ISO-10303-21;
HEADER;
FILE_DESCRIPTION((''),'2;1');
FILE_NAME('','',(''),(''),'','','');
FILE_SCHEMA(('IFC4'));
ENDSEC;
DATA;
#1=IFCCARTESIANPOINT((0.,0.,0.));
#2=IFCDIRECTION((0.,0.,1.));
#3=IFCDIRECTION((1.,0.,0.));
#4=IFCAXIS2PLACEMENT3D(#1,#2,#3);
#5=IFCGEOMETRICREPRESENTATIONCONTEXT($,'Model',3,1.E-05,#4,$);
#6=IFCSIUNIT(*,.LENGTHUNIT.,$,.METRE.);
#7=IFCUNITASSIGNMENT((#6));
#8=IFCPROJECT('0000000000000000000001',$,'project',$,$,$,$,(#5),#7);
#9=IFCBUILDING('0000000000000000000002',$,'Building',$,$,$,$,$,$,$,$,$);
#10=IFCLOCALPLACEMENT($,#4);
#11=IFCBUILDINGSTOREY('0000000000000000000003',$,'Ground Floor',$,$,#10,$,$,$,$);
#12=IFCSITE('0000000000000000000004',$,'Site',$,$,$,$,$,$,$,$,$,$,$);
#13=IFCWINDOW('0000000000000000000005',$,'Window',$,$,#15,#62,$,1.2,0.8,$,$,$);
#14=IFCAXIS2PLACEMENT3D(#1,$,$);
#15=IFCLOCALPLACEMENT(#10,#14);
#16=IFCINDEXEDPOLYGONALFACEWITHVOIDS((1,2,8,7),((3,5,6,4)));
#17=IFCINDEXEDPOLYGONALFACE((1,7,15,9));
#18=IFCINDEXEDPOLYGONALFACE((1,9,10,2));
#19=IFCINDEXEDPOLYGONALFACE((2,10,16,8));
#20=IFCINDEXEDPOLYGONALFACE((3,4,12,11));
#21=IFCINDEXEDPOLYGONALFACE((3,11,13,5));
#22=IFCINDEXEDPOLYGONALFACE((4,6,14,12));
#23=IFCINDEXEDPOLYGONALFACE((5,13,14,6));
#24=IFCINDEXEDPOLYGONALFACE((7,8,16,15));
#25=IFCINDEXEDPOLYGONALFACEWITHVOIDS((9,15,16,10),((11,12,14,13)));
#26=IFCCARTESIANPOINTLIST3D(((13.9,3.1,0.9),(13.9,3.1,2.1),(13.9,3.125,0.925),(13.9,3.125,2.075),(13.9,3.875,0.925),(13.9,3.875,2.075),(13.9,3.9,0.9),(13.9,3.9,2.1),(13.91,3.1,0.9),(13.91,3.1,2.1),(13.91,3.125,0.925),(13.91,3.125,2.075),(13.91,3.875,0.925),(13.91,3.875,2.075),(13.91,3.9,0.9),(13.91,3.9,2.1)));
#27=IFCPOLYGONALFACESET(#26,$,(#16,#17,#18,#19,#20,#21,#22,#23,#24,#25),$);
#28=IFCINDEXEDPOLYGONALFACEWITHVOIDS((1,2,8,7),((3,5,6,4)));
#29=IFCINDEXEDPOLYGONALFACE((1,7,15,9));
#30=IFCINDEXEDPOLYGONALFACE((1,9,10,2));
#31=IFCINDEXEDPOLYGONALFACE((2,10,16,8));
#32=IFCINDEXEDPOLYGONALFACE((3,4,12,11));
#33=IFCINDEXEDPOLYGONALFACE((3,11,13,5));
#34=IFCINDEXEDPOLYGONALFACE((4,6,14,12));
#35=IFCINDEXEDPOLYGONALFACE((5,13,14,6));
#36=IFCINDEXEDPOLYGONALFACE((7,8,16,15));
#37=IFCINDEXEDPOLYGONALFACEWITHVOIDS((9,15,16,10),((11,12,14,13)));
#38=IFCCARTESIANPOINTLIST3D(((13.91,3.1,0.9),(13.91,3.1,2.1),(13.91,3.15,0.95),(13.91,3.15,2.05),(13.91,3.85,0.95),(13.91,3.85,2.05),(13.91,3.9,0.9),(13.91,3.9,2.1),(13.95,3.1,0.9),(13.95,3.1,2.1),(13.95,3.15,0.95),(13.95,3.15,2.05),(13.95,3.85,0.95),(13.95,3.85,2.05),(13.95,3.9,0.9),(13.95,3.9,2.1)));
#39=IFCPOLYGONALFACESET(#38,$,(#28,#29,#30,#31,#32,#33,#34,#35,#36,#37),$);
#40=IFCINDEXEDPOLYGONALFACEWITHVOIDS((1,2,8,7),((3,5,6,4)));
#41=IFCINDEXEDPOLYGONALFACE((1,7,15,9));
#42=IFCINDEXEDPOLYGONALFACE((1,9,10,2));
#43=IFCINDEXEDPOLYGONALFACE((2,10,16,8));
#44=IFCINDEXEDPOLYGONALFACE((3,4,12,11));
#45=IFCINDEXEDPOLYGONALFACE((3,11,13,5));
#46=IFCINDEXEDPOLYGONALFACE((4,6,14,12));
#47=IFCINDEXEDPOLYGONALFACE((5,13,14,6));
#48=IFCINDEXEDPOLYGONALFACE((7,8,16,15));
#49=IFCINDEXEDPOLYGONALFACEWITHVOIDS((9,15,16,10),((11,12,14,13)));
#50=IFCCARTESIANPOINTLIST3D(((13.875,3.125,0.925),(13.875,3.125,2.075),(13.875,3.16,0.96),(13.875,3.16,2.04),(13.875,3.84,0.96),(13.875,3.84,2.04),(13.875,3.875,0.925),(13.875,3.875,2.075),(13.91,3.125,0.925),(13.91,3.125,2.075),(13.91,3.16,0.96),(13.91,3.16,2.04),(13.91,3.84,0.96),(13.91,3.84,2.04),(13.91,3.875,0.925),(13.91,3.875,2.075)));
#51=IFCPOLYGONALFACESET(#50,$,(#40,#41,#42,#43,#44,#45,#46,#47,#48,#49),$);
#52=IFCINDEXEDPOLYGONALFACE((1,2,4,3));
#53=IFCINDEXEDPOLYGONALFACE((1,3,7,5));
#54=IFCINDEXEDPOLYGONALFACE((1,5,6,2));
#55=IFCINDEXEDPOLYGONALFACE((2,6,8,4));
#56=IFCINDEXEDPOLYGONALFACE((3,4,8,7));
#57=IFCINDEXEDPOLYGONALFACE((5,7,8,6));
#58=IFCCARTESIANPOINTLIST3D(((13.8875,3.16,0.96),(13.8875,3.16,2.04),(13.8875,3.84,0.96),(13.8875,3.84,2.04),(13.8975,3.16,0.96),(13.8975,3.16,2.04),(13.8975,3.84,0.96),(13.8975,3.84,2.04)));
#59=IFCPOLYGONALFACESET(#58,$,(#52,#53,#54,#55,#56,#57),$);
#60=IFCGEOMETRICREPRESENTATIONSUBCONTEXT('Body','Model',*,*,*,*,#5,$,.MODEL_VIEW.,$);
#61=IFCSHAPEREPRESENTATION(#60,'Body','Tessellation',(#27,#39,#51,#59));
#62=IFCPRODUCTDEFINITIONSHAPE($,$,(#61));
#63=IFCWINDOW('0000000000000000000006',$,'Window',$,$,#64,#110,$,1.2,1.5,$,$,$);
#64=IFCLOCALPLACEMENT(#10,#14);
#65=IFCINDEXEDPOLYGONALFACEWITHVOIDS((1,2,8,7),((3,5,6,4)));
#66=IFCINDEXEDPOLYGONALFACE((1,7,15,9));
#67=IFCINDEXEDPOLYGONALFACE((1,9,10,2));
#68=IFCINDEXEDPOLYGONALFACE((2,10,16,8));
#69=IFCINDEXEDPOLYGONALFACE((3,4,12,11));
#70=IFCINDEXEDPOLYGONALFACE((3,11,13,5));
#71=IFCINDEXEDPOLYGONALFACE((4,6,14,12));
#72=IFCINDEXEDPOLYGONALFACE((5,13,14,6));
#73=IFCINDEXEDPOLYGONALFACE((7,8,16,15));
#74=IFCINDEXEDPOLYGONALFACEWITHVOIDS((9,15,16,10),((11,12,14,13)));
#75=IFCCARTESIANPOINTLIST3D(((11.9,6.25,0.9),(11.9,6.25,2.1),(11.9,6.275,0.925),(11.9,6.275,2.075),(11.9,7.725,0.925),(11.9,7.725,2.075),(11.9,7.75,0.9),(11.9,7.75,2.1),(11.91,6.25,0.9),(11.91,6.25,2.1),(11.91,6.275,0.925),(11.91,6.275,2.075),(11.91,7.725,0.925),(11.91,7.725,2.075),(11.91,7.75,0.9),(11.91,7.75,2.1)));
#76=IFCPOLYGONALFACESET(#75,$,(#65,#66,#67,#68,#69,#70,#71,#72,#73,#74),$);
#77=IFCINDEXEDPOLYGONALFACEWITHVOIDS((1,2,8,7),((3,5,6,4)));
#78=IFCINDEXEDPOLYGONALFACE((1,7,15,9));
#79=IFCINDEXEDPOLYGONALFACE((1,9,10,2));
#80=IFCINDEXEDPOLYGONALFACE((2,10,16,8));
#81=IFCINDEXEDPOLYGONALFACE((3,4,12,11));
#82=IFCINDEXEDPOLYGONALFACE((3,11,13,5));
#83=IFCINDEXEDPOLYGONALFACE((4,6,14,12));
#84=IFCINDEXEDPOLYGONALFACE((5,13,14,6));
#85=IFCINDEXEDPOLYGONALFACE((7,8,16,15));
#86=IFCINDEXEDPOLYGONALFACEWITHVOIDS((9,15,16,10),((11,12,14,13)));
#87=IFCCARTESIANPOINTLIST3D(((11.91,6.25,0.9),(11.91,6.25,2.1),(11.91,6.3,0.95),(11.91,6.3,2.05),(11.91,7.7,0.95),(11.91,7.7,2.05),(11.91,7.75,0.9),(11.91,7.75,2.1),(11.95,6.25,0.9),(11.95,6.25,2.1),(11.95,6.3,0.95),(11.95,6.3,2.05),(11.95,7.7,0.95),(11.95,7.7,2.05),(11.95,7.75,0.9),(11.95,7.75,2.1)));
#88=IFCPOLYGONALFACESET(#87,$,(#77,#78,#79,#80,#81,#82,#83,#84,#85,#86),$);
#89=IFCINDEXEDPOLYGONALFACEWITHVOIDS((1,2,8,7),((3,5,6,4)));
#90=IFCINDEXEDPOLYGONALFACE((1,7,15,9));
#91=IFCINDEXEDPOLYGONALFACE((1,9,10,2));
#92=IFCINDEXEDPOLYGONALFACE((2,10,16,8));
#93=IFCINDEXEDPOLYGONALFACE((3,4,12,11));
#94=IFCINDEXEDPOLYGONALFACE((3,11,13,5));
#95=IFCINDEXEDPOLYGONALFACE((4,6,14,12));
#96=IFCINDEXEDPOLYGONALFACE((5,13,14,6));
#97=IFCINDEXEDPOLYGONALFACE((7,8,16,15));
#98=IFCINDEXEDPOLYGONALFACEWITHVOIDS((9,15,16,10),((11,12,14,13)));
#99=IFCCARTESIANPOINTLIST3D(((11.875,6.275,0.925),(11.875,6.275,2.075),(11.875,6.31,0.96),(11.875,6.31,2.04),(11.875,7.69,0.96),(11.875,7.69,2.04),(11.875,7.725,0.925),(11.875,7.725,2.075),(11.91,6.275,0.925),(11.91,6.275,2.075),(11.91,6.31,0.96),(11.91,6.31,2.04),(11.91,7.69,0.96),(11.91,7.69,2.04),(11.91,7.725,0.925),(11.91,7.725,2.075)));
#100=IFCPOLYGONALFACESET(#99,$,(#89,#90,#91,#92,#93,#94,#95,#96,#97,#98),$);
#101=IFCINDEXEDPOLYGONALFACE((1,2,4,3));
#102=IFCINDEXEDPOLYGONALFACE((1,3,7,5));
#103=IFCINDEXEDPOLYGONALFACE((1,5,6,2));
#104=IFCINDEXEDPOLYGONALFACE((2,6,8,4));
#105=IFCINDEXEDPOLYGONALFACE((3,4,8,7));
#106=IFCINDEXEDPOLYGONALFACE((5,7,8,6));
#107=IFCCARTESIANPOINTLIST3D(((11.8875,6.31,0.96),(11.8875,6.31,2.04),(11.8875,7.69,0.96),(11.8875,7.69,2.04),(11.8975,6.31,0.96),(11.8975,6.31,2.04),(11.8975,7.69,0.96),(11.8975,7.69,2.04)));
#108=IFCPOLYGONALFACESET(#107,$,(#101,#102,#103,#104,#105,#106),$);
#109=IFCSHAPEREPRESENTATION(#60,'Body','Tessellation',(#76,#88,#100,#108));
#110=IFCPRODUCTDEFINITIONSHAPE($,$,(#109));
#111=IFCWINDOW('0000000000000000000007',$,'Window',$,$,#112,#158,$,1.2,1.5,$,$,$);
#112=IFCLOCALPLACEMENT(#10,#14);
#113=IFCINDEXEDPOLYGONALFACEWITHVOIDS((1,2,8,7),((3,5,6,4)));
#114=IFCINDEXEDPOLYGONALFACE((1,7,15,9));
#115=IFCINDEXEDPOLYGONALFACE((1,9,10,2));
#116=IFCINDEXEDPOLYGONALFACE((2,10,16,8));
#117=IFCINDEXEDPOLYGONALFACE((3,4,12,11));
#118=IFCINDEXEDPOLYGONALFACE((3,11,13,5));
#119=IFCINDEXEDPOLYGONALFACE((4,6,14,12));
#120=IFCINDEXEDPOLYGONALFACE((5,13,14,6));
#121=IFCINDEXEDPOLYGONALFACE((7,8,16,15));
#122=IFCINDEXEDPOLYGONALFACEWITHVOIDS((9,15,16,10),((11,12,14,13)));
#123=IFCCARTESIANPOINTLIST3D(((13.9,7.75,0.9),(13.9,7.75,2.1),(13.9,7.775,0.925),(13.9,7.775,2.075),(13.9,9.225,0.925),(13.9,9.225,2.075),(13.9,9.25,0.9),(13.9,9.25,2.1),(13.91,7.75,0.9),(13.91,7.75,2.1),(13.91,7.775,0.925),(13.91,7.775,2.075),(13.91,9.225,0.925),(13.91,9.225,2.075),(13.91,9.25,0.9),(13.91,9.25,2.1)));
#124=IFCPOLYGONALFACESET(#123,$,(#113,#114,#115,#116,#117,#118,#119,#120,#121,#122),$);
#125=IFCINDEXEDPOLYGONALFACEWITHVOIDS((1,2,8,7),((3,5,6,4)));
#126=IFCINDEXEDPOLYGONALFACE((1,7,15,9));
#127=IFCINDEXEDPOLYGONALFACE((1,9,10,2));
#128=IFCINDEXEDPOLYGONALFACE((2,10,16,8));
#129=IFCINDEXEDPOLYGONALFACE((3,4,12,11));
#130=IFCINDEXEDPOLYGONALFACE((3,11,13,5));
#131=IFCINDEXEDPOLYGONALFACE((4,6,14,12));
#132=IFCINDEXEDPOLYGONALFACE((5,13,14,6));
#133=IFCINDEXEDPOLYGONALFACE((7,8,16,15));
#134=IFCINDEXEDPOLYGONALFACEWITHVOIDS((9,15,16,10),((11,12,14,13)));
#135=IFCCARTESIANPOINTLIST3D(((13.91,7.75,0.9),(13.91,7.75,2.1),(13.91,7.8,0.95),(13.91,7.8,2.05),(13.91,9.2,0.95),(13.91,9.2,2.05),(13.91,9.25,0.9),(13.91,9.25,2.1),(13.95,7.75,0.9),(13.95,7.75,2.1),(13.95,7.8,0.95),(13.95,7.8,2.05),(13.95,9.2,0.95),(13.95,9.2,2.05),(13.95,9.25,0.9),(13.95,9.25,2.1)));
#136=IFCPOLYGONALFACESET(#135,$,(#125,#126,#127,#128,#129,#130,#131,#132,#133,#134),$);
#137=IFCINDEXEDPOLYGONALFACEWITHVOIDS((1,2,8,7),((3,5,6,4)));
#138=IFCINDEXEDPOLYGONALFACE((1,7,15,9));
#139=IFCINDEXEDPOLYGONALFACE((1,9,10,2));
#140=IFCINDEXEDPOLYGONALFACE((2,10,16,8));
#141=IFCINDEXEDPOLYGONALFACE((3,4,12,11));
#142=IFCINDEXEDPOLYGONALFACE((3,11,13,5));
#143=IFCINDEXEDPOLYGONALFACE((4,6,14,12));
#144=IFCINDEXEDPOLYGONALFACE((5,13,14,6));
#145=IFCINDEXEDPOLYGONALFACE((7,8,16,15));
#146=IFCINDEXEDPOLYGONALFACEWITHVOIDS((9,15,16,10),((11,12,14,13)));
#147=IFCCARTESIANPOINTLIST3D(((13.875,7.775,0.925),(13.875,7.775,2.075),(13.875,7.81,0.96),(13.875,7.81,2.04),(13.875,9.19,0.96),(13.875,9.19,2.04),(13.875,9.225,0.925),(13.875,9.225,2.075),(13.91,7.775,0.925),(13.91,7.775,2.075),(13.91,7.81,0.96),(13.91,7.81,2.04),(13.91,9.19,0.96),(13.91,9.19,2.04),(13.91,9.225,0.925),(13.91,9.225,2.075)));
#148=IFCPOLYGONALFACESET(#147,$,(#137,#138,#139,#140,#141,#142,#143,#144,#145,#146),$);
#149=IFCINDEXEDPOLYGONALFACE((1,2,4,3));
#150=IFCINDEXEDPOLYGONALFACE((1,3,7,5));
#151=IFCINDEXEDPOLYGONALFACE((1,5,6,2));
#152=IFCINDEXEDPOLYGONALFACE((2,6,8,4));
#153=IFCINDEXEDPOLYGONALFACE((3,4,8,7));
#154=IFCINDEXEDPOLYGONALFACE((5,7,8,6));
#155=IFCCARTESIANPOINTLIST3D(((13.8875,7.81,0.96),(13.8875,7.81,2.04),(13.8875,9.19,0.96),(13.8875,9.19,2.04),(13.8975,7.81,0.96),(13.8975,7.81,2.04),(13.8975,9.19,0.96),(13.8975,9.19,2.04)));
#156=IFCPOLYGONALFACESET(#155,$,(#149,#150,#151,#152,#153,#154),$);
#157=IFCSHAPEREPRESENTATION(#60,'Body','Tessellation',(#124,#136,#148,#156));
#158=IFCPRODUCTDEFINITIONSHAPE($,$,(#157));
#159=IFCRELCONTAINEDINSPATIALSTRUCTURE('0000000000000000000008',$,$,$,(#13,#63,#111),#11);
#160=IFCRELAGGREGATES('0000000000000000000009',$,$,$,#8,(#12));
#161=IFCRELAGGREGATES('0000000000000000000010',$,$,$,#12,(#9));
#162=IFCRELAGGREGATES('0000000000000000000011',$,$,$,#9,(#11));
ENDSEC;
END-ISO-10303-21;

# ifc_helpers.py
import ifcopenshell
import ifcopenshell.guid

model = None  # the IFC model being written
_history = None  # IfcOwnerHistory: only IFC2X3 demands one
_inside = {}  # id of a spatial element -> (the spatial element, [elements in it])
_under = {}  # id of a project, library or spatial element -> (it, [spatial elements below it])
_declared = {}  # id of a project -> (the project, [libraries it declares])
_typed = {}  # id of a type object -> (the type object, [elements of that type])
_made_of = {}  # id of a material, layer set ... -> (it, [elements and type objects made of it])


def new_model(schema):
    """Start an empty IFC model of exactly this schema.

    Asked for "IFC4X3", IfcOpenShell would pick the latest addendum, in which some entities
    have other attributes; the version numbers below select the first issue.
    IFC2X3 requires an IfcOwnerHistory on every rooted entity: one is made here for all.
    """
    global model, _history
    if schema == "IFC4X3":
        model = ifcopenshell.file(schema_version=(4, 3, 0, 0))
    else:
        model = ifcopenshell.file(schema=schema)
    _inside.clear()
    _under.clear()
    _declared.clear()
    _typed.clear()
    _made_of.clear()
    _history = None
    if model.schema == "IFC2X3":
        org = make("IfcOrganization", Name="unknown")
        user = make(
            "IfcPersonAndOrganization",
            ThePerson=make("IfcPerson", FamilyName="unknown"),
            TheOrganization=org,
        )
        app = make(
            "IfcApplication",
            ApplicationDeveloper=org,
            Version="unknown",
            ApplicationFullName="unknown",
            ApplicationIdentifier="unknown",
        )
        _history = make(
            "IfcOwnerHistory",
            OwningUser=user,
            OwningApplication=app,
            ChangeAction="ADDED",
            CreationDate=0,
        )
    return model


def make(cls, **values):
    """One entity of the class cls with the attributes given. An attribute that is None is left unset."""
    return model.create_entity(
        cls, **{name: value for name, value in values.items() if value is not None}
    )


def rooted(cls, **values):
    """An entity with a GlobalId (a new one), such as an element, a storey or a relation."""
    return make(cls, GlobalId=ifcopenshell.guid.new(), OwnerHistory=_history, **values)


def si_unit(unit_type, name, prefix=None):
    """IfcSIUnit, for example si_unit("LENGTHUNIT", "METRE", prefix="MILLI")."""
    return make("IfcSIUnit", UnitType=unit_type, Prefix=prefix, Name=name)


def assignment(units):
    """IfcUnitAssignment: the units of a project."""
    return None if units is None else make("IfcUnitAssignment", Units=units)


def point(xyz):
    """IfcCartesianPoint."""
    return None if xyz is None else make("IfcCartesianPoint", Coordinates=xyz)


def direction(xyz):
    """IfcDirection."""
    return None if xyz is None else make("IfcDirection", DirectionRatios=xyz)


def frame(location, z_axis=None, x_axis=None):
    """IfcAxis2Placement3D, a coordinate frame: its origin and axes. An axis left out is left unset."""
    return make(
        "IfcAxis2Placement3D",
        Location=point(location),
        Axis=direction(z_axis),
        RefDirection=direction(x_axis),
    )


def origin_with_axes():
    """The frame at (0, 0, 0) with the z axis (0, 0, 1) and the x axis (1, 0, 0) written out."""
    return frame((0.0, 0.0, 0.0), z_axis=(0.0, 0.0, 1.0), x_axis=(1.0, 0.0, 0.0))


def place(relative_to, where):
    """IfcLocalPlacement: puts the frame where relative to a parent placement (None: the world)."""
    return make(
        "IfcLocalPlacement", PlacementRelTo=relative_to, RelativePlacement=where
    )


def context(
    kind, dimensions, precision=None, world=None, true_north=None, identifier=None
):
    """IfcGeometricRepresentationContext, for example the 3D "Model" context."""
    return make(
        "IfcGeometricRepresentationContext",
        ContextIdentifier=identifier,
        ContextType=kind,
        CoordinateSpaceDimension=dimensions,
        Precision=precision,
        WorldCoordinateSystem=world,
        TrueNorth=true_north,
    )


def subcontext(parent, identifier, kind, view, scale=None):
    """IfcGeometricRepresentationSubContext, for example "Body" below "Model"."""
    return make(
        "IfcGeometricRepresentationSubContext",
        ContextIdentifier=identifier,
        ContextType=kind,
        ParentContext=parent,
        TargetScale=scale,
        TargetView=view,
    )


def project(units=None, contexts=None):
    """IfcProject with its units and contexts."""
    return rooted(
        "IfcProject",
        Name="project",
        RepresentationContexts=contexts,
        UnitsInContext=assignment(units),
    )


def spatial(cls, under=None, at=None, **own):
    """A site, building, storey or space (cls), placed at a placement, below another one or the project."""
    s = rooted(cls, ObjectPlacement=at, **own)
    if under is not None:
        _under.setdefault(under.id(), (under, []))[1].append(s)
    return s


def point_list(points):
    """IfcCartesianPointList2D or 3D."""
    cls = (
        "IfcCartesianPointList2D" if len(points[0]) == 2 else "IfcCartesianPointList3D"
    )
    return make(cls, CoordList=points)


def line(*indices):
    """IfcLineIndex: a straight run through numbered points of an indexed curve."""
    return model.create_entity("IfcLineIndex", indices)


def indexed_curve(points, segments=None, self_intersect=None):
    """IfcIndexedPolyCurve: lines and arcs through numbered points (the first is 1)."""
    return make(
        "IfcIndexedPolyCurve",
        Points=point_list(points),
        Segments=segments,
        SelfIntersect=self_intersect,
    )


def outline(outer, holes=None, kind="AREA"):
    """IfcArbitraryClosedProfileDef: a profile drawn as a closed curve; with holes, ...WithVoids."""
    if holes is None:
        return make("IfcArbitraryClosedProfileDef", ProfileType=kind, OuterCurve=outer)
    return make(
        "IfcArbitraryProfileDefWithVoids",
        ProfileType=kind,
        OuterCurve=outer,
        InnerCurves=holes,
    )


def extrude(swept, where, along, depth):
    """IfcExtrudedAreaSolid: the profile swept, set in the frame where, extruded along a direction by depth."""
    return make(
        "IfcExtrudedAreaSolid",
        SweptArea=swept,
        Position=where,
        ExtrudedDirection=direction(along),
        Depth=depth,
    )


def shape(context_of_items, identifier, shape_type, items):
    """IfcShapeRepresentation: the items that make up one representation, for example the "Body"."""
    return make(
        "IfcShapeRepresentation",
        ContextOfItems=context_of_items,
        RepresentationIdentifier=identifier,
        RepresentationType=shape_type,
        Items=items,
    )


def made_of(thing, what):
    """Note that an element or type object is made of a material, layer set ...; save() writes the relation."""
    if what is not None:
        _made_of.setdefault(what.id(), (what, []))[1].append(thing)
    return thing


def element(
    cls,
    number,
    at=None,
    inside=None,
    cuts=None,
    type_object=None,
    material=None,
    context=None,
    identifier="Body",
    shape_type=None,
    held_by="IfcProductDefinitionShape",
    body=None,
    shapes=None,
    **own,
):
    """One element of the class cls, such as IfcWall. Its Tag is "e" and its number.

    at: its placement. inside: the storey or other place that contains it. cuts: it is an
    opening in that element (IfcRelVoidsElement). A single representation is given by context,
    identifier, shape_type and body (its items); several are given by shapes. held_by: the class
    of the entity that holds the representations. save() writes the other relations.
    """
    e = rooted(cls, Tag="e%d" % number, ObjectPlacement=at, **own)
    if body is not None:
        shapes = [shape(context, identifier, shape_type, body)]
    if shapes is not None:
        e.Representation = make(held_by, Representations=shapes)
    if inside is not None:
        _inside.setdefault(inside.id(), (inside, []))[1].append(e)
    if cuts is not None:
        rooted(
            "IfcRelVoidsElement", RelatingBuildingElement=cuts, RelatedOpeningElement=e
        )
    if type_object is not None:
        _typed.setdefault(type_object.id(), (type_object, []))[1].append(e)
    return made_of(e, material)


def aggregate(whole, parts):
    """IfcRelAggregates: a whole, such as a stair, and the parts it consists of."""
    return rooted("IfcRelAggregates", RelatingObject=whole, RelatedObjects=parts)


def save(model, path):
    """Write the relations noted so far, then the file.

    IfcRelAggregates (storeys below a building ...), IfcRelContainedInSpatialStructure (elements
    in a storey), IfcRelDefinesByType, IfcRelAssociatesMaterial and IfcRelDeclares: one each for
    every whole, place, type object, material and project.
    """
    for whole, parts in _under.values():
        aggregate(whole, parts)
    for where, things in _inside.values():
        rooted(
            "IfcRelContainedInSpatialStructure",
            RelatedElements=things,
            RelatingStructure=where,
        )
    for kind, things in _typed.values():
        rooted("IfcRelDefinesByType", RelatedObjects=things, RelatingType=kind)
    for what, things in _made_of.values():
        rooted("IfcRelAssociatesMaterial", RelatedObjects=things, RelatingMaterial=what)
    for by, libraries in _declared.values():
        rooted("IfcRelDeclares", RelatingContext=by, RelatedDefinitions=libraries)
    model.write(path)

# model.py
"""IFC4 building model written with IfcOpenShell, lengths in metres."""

from ifc_helpers import new_model, si_unit, frame, origin_with_axes, place, context, subcontext, project, spatial, line, indexed_curve, outline, extrude, element, save


model = new_model("IFC4")

# Units and contexts
model_context = context("Model", 3, precision=1e-05, world=origin_with_axes())
body_context = subcontext(model_context, "Body", "Model", "MODEL_VIEW")
ifc_project = project(units=[si_unit("LENGTHUNIT", "METRE")], contexts=[model_context])

# Site, building, storey
site = spatial("IfcSite", under=ifc_project, Name="Site")
building = spatial("IfcBuilding", under=site, Name="Building")
storey_placement = place(None, origin_with_axes())
storey = spatial("IfcBuildingStorey", under=building, at=storey_placement, Name="Ground Floor")

# Windows
window_1_placement = place(storey_placement, frame((14.0, 3.1, 0.9), z_axis=(0.0, 0.0, 1.0), x_axis=(0.0, 1.0, 0.0)))
element("IfcWindow", 1, at=window_1_placement, inside=storey, Name="Window", OverallHeight=1.2, OverallWidth=0.8, context=body_context, shape_type="SweptSolid", body=[
    extrude(outline(indexed_curve([(0.0, 0.0), (0.8, 0.0), (0.8, 1.2), (0.0, 1.2)], segments=[line(1, 2, 3, 4, 1)]), holes=[indexed_curve([(0.025, 0.025), (0.775, 0.025), (0.775, 1.175), (0.025, 1.175)], segments=[line(1, 2, 3, 4, 1)])]), frame((0.0, 0.09, 0.0), z_axis=(0.0, -1.0, 0.0), x_axis=(1.0, 0.0, 0.0)), (0.0, 0.0, -1.0), 0.01),
    extrude(outline(indexed_curve([(0.0, 0.0), (0.8, 0.0), (0.8, 1.2), (0.0, 1.2)], segments=[line(1, 2, 3, 4, 1)]), holes=[indexed_curve([(0.05, 0.05), (0.75, 0.05), (0.75, 1.15), (0.05, 1.15)], segments=[line(1, 2, 3, 4, 1)])]), frame((0.0, 0.05, 0.0), z_axis=(0.0, -1.0, 0.0), x_axis=(1.0, 0.0, 0.0)), (0.0, 0.0, -1.0), 0.04),
    extrude(outline(indexed_curve([(0.0, 0.0), (0.75, 0.0), (0.75, 1.15), (0.0, 1.15)], segments=[line(1, 2, 3, 4, 1)]), holes=[indexed_curve([(0.035, 0.035), (0.715, 0.035), (0.715, 1.115), (0.035, 1.115)], segments=[line(1, 2, 3, 4, 1)])]), frame((0.025, 0.09, 0.025), z_axis=(0.0, -1.0, 0.0), x_axis=(1.0, 0.0, 0.0)), (0.0, 0.0, -1.0), 0.035),
    extrude(outline(indexed_curve([(0.035, 0.035), (0.715, 0.035), (0.715, 1.115), (0.035, 1.115)], segments=[line(1, 2, 3, 4, 1)])), frame((0.025, 0.1025, 0.025), z_axis=(0.0, -1.0, 0.0), x_axis=(1.0, 0.0, 0.0)), (0.0, 0.0, -1.0), 0.01),
])
for number, where, z_axis, x_axis, name in (
    (2, (12.0, 6.25, 0.9), (0.0, 0.0, 1.0), (0.0, 1.0, 0.0), "Window"),
    (3, (14.0, 7.75, 0.9), (0.0, 0.0, 1.0), (0.0, 1.0, 0.0), "Window"),
):
    element("IfcWindow", number, at=place(storey_placement, frame(where, z_axis=z_axis, x_axis=x_axis)), inside=storey, Name=name, OverallHeight=1.2, OverallWidth=1.5, context=body_context, shape_type="SweptSolid", body=[
        extrude(outline(indexed_curve([(0.0, 0.0), (1.5, 0.0), (1.5, 1.2), (0.0, 1.2)], segments=[line(1, 2, 3, 4, 1)]), holes=[indexed_curve([(0.025, 0.025), (1.475, 0.025), (1.475, 1.175), (0.025, 1.175)], segments=[line(1, 2, 3, 4, 1)])]), frame((0.0, 0.09, 0.0), z_axis=(0.0, -1.0, 0.0), x_axis=(1.0, 0.0, 0.0)), (0.0, 0.0, -1.0), 0.01),
        extrude(outline(indexed_curve([(0.0, 0.0), (1.5, 0.0), (1.5, 1.2), (0.0, 1.2)], segments=[line(1, 2, 3, 4, 1)]), holes=[indexed_curve([(0.05, 0.05), (1.45, 0.05), (1.45, 1.15), (0.05, 1.15)], segments=[line(1, 2, 3, 4, 1)])]), frame((0.0, 0.05, 0.0), z_axis=(0.0, -1.0, 0.0), x_axis=(1.0, 0.0, 0.0)), (0.0, 0.0, -1.0), 0.04),
        extrude(outline(indexed_curve([(0.0, 0.0), (1.45, 0.0), (1.45, 1.15), (0.0, 1.15)], segments=[line(1, 2, 3, 4, 1)]), holes=[indexed_curve([(0.035, 0.035), (1.415, 0.035), (1.415, 1.115), (0.035, 1.115)], segments=[line(1, 2, 3, 4, 1)])]), frame((0.025, 0.09, 0.025), z_axis=(0.0, -1.0, 0.0), x_axis=(1.0, 0.0, 0.0)), (0.0, 0.0, -1.0), 0.035),
        extrude(outline(indexed_curve([(0.035, 0.035), (1.415, 0.035), (1.415, 1.115), (0.035, 1.115)], segments=[line(1, 2, 3, 4, 1)])), frame((0.025, 0.1025, 0.025), z_axis=(0.0, -1.0, 0.0), x_axis=(1.0, 0.0, 0.0)), (0.0, 0.0, -1.0), 0.01),
    ])

save(model, "model.ifc")
